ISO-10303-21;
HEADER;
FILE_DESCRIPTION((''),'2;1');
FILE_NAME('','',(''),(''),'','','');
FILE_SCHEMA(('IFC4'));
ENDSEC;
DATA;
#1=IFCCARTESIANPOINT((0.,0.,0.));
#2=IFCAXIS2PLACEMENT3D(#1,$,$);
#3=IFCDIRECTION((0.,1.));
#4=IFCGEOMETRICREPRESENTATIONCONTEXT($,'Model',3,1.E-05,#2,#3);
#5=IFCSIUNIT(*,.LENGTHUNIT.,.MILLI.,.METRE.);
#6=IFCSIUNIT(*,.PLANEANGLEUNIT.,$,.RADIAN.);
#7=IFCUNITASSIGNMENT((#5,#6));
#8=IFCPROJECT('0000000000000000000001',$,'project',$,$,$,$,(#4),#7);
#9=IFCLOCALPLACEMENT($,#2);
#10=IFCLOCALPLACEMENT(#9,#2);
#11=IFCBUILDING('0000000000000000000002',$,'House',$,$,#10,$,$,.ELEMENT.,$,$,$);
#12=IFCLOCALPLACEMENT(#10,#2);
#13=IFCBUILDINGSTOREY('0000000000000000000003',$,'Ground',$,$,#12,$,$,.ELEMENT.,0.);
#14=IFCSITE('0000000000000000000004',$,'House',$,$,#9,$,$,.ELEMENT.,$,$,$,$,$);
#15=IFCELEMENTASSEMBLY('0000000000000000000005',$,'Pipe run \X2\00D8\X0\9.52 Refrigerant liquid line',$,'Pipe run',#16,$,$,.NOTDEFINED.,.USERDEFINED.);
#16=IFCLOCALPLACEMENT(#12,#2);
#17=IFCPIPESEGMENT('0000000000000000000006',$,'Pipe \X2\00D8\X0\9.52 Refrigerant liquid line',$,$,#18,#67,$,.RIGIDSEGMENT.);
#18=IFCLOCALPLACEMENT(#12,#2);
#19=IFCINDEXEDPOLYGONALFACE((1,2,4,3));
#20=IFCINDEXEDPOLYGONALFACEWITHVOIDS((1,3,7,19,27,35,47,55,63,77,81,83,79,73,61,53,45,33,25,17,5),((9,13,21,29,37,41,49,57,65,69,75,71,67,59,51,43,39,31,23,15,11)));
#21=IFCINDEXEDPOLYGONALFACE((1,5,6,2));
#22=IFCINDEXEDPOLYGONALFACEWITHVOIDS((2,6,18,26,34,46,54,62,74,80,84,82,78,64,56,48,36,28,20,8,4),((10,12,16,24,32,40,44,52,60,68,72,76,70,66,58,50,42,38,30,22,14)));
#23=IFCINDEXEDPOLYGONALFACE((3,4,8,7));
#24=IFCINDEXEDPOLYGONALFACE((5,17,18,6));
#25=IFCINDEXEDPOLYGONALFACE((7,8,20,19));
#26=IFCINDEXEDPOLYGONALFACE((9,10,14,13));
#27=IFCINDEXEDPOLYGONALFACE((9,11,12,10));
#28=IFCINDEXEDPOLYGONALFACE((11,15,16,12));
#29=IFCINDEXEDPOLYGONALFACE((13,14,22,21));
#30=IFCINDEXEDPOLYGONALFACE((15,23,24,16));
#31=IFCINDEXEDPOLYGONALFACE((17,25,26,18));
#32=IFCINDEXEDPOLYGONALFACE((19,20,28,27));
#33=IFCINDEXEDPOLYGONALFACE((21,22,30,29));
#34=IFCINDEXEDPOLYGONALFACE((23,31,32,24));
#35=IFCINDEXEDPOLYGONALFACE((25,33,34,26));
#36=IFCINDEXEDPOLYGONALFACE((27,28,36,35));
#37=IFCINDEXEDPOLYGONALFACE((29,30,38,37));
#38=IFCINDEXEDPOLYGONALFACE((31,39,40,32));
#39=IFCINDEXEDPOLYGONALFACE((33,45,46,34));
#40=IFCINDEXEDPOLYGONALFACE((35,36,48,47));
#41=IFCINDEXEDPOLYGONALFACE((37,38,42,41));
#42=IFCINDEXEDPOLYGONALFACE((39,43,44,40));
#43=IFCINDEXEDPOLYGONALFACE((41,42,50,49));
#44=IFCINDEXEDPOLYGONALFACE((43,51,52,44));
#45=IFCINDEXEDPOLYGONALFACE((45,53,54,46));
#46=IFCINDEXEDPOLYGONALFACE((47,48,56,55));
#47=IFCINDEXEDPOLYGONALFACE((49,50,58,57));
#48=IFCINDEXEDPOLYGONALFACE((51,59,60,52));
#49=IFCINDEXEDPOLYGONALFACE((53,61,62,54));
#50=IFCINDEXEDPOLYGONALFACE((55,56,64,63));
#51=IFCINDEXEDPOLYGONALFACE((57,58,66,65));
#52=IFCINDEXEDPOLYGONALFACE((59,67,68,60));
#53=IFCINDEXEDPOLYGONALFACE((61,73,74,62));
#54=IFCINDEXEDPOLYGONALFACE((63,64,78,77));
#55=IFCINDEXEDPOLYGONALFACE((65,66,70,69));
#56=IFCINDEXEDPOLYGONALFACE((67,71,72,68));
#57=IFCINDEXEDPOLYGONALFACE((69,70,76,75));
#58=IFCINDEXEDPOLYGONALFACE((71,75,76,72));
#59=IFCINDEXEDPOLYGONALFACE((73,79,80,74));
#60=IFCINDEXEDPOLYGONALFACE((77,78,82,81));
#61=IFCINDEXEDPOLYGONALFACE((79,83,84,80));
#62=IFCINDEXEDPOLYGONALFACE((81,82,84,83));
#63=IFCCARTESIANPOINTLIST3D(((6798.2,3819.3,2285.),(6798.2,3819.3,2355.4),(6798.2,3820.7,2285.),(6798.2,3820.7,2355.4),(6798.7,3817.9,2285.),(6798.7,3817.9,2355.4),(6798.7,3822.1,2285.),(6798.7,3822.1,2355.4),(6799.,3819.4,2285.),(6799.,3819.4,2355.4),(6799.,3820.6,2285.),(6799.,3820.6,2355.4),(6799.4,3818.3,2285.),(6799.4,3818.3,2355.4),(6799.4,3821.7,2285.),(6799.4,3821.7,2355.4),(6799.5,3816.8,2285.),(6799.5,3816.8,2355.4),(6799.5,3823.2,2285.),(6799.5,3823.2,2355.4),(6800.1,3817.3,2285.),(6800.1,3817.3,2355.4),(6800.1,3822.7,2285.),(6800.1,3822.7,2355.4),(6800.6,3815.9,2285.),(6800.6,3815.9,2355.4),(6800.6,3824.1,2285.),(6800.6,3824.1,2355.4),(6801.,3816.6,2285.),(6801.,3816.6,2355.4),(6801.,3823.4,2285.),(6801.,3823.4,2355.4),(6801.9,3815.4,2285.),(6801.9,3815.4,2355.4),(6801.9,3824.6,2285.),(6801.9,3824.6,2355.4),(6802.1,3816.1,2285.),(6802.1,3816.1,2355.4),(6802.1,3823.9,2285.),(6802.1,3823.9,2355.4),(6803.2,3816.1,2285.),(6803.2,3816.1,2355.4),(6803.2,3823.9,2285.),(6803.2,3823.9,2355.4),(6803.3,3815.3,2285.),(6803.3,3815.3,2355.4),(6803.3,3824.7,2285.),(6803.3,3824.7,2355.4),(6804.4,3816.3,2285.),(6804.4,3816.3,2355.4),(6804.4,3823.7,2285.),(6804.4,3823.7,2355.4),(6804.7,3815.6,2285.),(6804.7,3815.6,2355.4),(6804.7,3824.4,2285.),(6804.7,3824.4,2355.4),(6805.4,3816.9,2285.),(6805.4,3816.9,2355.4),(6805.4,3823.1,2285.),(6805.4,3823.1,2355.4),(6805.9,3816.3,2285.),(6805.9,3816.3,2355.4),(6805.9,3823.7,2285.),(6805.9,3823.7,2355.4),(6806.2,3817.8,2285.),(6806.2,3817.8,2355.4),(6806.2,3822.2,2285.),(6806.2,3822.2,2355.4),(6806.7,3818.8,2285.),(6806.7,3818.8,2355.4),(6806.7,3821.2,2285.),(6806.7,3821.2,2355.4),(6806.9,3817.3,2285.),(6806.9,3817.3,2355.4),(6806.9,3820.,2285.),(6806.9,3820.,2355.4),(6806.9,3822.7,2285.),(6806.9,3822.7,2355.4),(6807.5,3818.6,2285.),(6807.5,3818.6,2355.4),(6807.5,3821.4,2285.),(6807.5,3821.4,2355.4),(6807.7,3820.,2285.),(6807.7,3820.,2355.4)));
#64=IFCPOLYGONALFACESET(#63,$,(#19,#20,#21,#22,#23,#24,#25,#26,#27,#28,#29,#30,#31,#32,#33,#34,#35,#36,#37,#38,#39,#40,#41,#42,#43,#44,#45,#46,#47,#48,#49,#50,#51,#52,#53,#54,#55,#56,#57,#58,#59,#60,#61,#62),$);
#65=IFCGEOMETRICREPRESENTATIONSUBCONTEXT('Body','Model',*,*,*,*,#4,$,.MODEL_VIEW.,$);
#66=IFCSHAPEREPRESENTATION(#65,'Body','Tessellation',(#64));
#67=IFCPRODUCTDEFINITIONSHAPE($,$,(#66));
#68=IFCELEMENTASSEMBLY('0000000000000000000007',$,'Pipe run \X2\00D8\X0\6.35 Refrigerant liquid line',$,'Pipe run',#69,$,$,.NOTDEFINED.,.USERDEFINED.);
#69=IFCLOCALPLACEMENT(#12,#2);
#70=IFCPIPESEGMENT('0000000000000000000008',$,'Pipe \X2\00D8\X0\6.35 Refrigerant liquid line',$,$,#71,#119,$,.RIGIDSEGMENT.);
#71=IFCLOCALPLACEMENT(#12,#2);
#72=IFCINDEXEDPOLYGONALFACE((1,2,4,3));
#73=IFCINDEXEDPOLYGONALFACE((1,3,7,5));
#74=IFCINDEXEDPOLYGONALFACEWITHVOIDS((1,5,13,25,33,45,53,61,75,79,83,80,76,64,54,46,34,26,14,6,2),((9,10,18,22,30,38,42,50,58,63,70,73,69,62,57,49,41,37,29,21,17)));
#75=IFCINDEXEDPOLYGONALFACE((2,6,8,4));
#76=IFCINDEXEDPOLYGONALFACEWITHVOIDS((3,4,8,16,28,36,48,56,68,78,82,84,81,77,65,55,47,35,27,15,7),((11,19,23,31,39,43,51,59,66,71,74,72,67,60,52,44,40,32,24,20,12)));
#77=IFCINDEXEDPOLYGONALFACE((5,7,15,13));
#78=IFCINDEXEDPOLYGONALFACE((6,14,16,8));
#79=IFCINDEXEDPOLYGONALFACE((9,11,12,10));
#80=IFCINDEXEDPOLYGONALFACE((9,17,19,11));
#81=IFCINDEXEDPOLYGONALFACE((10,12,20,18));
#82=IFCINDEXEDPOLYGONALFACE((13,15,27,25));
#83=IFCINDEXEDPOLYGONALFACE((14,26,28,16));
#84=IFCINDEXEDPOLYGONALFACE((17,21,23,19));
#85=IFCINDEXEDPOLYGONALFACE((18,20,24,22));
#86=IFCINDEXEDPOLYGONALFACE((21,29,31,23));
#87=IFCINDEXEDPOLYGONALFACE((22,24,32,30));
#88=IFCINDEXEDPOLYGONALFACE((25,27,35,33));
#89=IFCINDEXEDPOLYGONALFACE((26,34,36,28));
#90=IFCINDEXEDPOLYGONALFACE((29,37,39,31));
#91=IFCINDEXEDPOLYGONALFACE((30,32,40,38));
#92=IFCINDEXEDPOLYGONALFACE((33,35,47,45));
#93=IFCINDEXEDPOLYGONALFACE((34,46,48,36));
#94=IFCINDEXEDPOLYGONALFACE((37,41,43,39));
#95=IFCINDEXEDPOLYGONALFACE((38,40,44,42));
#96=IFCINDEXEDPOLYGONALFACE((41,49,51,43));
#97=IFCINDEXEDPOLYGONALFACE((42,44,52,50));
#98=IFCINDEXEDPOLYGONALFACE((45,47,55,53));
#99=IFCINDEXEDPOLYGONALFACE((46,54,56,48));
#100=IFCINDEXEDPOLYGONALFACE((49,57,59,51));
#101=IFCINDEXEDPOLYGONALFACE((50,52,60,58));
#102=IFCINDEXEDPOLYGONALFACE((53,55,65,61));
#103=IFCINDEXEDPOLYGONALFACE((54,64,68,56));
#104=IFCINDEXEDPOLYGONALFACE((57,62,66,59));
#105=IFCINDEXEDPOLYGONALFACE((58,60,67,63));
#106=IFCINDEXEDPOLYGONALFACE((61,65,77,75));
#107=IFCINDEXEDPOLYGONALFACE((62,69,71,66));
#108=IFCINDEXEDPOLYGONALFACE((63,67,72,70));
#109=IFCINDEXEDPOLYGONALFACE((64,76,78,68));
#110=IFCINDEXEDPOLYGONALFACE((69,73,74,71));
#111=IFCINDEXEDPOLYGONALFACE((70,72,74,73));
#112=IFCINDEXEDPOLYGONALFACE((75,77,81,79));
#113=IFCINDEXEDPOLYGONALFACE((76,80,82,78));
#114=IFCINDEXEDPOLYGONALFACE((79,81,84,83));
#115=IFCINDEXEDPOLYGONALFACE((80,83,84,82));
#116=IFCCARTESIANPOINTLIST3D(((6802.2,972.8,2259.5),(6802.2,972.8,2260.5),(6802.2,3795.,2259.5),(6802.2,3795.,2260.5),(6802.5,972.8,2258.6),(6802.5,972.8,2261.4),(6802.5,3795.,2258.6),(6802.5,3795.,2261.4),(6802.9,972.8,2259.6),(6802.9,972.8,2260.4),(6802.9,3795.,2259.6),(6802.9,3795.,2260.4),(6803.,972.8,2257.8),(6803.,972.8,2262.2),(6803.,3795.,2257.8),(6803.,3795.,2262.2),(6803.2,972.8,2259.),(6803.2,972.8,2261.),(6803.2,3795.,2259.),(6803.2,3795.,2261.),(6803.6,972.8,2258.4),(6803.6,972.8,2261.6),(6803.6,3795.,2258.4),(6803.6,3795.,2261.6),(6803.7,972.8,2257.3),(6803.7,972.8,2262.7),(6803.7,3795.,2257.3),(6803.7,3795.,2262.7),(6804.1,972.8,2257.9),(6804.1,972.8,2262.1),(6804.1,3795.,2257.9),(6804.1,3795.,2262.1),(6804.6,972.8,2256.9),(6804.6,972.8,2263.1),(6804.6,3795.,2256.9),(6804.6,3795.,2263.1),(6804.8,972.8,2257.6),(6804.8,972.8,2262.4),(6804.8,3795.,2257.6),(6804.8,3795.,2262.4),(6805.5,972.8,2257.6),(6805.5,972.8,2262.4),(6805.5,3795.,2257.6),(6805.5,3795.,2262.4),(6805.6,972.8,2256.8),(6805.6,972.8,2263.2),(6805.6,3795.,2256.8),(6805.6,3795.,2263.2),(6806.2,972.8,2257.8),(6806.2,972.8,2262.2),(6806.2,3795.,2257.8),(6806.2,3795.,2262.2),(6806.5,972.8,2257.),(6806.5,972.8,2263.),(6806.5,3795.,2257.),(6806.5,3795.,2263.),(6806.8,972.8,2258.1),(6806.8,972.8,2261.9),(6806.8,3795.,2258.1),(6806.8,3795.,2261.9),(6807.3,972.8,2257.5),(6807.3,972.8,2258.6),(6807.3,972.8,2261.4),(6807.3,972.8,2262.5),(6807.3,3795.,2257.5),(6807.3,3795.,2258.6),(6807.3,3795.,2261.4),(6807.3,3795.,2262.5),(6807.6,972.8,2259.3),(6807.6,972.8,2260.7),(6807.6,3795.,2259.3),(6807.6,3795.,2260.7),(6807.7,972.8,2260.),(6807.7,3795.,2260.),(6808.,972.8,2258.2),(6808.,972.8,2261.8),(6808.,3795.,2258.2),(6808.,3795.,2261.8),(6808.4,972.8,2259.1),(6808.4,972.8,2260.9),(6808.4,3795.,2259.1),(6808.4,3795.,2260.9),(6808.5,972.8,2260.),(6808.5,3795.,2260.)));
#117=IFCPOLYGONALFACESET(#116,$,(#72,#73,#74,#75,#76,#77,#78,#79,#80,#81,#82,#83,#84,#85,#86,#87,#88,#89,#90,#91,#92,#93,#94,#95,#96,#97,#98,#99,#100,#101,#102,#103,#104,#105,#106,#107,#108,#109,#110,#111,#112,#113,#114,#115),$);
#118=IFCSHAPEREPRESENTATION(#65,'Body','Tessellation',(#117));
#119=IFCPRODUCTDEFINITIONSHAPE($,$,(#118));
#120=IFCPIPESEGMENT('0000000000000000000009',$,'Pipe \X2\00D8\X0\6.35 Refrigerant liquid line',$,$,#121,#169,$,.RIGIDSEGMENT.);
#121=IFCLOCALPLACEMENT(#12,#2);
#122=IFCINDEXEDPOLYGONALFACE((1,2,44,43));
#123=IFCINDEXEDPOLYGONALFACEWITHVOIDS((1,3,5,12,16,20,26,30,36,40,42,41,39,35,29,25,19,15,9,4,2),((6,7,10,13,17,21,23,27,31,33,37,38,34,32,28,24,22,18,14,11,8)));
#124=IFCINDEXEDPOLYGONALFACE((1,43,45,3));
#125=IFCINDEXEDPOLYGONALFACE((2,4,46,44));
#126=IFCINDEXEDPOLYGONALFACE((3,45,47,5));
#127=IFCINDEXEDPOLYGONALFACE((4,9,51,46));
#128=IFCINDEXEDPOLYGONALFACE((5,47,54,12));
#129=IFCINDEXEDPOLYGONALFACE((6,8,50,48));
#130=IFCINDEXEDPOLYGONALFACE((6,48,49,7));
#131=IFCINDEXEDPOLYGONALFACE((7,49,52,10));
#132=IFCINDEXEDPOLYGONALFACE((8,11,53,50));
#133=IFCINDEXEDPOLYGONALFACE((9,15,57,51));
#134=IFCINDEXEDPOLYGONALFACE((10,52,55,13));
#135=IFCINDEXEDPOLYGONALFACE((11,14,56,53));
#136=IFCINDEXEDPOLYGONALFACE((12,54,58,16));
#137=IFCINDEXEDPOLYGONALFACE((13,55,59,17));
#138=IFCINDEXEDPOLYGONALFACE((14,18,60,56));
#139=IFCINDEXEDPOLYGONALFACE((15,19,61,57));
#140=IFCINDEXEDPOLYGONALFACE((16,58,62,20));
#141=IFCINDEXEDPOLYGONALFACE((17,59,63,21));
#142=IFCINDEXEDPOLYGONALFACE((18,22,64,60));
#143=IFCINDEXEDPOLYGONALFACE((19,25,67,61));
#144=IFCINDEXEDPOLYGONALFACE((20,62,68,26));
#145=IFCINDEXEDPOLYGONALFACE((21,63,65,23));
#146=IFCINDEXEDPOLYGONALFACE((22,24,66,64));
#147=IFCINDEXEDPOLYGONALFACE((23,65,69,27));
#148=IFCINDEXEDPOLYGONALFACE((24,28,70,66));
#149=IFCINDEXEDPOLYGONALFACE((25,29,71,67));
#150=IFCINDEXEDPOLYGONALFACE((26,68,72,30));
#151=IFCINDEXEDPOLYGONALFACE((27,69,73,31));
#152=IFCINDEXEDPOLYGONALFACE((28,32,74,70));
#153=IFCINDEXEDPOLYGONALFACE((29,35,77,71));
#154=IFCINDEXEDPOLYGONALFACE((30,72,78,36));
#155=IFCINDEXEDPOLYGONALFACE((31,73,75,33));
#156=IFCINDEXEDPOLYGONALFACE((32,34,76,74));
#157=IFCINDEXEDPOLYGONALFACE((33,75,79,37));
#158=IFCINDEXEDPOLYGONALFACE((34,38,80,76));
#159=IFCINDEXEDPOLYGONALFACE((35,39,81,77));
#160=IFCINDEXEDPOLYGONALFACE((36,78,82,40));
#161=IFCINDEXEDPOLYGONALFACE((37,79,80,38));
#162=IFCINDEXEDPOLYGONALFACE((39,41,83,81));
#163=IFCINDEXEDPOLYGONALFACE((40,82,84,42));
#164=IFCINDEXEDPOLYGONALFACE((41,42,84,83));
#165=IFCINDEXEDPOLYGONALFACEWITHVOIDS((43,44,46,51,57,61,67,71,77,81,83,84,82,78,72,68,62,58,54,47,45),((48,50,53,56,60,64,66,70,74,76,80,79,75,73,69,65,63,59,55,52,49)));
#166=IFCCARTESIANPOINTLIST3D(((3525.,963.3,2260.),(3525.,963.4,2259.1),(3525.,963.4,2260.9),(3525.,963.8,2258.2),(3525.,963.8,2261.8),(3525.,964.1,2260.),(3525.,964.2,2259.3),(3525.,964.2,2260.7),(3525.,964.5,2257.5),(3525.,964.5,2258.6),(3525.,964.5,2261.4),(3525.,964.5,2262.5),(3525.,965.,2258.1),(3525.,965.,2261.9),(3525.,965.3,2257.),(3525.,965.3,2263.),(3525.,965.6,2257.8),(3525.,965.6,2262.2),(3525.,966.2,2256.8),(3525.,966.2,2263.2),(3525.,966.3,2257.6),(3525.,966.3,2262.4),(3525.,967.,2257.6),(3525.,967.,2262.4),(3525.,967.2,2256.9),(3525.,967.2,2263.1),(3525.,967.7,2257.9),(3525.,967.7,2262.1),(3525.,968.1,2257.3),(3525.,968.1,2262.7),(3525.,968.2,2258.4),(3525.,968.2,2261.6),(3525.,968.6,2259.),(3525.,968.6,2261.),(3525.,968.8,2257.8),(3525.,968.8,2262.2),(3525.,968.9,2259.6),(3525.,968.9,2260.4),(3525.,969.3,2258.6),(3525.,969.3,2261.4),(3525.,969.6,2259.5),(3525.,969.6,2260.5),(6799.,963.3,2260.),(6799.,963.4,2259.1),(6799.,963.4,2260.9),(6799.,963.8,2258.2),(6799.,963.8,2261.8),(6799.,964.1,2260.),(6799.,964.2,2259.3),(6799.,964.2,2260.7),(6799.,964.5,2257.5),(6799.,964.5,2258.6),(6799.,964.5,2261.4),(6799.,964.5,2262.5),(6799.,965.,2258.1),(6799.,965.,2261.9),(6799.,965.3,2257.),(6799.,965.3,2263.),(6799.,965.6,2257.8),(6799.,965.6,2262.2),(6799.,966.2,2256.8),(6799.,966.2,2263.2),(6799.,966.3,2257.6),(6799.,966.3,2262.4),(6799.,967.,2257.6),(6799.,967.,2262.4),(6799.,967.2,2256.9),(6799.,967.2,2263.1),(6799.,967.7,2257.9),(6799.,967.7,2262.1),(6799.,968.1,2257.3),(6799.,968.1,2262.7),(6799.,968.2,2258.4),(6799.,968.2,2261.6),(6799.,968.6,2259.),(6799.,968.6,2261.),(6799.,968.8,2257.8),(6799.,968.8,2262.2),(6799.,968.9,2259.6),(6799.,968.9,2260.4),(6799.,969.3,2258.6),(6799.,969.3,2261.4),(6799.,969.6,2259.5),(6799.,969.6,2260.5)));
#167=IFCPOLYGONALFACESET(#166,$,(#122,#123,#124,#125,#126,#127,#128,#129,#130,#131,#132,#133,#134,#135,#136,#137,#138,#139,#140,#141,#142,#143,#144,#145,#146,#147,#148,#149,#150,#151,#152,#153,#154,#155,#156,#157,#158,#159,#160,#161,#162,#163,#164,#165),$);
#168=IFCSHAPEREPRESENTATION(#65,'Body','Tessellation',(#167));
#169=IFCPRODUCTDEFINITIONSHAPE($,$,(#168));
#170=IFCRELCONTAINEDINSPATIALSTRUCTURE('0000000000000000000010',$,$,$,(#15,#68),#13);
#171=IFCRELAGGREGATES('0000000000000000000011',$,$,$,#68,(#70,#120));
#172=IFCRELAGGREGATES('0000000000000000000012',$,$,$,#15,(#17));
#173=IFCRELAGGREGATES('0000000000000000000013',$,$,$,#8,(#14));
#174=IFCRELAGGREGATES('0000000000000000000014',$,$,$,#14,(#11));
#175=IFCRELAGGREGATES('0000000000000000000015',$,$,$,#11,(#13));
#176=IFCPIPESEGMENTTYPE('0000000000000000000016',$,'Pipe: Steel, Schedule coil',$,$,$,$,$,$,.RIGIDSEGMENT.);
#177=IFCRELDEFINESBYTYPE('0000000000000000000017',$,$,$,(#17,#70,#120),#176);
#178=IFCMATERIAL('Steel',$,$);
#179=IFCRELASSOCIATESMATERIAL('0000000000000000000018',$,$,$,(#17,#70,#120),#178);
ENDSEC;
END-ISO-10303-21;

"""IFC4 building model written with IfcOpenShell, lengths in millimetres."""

from ifc_helpers import new_model, si_unit, direction, frame, origin, origin_with_axes, origin_2d, place, context, subcontext, project, spatial, hollow_circle, extrude, material, type_object, element, aggregate, save


model = new_model("IFC4")

# Units and contexts
model_context = context("Model", 3, precision=1e-05, world=origin(), true_north=direction((0.0, 1.0)))
body_context = subcontext(model_context, "Body", "Model", "MODEL_VIEW")
ifc_project = project(units=[si_unit("LENGTHUNIT", "METRE", prefix="MILLI"), si_unit("PLANEANGLEUNIT", "RADIAN")], contexts=[model_context])

# Site, building, storey
site_placement = place(None, origin())
site = spatial("IfcSite", under=ifc_project, at=site_placement, Name="House", CompositionType="ELEMENT")
building_placement = place(site_placement, origin())
building = spatial("IfcBuilding", under=site, at=building_placement, Name="House", CompositionType="ELEMENT")
storey_placement = place(building_placement, origin())
storey = spatial("IfcBuildingStorey", under=building, at=storey_placement, Name="Ground", CompositionType="ELEMENT", Elevation=0.0)

# Element assembly, pipe segment
assembly_1_placement = place(storey_placement, origin_with_axes())
assembly_1 = element("IfcElementAssembly", 1, at=assembly_1_placement, inside=storey, Name="Pipe run Ø9.52 Refrigerant liquid line", ObjectType="Pipe run", AssemblyPlace="NOTDEFINED", PredefinedType="USERDEFINED")
ifc_material_1 = material(Name="Steel")
pipe_segment_type_1 = type_object("IfcPipeSegmentType", Name="Pipe: Steel, Schedule coil", PredefinedType="RIGIDSEGMENT")
pipe_segment_1_placement = place(storey_placement, origin_with_axes())
pipe_segment_1 = element("IfcPipeSegment", 2, at=pipe_segment_1_placement, type_object=pipe_segment_type_1, material=ifc_material_1, Name="Pipe Ø9.52 Refrigerant liquid line", PredefinedType="RIGIDSEGMENT", context=body_context, shape_type="SweptSolid", body=[
    extrude(hollow_circle(Radius=4.8, WallThickness=0.8, at=origin_2d()), frame((6802.9, 3820.0, 2285.0), z_axis=(0.0, 0.0, 1.0), x_axis=(1.0, 0.0, 0.0)), (0.0, 0.0, 1.0), 70.4),
])

# Element assembly, pipe segments
assembly_2_placement = place(storey_placement, origin_with_axes())
assembly_2 = element("IfcElementAssembly", 3, at=assembly_2_placement, inside=storey, Name="Pipe run Ø6.35 Refrigerant liquid line", ObjectType="Pipe run", AssemblyPlace="NOTDEFINED", PredefinedType="USERDEFINED")
pipe_segment_2_placement = place(storey_placement, origin_with_axes())
pipe_segment_2 = element("IfcPipeSegment", 4, at=pipe_segment_2_placement, type_object=pipe_segment_type_1, material=ifc_material_1, Name="Pipe Ø6.35 Refrigerant liquid line", PredefinedType="RIGIDSEGMENT", context=body_context, shape_type="SweptSolid", body=[
    extrude(hollow_circle(Radius=3.2, WallThickness=0.8, at=origin_2d()), frame((6805.3, 3795.0, 2260.0), z_axis=(0.0, -1.0, 0.0), x_axis=(1.0, 0.0, 0.0)), (0.0, 0.0, 1.0), 2822.2),
])
pipe_segment_3_placement = place(storey_placement, origin_with_axes())
pipe_segment_3 = element("IfcPipeSegment", 5, at=pipe_segment_3_placement, type_object=pipe_segment_type_1, material=ifc_material_1, Name="Pipe Ø6.35 Refrigerant liquid line", PredefinedType="RIGIDSEGMENT", context=body_context, shape_type="SweptSolid", body=[
    extrude(hollow_circle(Radius=3.2, WallThickness=0.8, at=origin_2d()), frame((6799.0, 966.5, 2260.0), z_axis=(-1.0, 0.0, 0.0), x_axis=(0.0, -1.0, 0.0)), (0.0, 0.0, 1.0), 3274.0),
])
aggregate(assembly_2, [pipe_segment_2, pipe_segment_3])

aggregate(assembly_1, [pipe_segment_1])

save(model, "model.ifc")
